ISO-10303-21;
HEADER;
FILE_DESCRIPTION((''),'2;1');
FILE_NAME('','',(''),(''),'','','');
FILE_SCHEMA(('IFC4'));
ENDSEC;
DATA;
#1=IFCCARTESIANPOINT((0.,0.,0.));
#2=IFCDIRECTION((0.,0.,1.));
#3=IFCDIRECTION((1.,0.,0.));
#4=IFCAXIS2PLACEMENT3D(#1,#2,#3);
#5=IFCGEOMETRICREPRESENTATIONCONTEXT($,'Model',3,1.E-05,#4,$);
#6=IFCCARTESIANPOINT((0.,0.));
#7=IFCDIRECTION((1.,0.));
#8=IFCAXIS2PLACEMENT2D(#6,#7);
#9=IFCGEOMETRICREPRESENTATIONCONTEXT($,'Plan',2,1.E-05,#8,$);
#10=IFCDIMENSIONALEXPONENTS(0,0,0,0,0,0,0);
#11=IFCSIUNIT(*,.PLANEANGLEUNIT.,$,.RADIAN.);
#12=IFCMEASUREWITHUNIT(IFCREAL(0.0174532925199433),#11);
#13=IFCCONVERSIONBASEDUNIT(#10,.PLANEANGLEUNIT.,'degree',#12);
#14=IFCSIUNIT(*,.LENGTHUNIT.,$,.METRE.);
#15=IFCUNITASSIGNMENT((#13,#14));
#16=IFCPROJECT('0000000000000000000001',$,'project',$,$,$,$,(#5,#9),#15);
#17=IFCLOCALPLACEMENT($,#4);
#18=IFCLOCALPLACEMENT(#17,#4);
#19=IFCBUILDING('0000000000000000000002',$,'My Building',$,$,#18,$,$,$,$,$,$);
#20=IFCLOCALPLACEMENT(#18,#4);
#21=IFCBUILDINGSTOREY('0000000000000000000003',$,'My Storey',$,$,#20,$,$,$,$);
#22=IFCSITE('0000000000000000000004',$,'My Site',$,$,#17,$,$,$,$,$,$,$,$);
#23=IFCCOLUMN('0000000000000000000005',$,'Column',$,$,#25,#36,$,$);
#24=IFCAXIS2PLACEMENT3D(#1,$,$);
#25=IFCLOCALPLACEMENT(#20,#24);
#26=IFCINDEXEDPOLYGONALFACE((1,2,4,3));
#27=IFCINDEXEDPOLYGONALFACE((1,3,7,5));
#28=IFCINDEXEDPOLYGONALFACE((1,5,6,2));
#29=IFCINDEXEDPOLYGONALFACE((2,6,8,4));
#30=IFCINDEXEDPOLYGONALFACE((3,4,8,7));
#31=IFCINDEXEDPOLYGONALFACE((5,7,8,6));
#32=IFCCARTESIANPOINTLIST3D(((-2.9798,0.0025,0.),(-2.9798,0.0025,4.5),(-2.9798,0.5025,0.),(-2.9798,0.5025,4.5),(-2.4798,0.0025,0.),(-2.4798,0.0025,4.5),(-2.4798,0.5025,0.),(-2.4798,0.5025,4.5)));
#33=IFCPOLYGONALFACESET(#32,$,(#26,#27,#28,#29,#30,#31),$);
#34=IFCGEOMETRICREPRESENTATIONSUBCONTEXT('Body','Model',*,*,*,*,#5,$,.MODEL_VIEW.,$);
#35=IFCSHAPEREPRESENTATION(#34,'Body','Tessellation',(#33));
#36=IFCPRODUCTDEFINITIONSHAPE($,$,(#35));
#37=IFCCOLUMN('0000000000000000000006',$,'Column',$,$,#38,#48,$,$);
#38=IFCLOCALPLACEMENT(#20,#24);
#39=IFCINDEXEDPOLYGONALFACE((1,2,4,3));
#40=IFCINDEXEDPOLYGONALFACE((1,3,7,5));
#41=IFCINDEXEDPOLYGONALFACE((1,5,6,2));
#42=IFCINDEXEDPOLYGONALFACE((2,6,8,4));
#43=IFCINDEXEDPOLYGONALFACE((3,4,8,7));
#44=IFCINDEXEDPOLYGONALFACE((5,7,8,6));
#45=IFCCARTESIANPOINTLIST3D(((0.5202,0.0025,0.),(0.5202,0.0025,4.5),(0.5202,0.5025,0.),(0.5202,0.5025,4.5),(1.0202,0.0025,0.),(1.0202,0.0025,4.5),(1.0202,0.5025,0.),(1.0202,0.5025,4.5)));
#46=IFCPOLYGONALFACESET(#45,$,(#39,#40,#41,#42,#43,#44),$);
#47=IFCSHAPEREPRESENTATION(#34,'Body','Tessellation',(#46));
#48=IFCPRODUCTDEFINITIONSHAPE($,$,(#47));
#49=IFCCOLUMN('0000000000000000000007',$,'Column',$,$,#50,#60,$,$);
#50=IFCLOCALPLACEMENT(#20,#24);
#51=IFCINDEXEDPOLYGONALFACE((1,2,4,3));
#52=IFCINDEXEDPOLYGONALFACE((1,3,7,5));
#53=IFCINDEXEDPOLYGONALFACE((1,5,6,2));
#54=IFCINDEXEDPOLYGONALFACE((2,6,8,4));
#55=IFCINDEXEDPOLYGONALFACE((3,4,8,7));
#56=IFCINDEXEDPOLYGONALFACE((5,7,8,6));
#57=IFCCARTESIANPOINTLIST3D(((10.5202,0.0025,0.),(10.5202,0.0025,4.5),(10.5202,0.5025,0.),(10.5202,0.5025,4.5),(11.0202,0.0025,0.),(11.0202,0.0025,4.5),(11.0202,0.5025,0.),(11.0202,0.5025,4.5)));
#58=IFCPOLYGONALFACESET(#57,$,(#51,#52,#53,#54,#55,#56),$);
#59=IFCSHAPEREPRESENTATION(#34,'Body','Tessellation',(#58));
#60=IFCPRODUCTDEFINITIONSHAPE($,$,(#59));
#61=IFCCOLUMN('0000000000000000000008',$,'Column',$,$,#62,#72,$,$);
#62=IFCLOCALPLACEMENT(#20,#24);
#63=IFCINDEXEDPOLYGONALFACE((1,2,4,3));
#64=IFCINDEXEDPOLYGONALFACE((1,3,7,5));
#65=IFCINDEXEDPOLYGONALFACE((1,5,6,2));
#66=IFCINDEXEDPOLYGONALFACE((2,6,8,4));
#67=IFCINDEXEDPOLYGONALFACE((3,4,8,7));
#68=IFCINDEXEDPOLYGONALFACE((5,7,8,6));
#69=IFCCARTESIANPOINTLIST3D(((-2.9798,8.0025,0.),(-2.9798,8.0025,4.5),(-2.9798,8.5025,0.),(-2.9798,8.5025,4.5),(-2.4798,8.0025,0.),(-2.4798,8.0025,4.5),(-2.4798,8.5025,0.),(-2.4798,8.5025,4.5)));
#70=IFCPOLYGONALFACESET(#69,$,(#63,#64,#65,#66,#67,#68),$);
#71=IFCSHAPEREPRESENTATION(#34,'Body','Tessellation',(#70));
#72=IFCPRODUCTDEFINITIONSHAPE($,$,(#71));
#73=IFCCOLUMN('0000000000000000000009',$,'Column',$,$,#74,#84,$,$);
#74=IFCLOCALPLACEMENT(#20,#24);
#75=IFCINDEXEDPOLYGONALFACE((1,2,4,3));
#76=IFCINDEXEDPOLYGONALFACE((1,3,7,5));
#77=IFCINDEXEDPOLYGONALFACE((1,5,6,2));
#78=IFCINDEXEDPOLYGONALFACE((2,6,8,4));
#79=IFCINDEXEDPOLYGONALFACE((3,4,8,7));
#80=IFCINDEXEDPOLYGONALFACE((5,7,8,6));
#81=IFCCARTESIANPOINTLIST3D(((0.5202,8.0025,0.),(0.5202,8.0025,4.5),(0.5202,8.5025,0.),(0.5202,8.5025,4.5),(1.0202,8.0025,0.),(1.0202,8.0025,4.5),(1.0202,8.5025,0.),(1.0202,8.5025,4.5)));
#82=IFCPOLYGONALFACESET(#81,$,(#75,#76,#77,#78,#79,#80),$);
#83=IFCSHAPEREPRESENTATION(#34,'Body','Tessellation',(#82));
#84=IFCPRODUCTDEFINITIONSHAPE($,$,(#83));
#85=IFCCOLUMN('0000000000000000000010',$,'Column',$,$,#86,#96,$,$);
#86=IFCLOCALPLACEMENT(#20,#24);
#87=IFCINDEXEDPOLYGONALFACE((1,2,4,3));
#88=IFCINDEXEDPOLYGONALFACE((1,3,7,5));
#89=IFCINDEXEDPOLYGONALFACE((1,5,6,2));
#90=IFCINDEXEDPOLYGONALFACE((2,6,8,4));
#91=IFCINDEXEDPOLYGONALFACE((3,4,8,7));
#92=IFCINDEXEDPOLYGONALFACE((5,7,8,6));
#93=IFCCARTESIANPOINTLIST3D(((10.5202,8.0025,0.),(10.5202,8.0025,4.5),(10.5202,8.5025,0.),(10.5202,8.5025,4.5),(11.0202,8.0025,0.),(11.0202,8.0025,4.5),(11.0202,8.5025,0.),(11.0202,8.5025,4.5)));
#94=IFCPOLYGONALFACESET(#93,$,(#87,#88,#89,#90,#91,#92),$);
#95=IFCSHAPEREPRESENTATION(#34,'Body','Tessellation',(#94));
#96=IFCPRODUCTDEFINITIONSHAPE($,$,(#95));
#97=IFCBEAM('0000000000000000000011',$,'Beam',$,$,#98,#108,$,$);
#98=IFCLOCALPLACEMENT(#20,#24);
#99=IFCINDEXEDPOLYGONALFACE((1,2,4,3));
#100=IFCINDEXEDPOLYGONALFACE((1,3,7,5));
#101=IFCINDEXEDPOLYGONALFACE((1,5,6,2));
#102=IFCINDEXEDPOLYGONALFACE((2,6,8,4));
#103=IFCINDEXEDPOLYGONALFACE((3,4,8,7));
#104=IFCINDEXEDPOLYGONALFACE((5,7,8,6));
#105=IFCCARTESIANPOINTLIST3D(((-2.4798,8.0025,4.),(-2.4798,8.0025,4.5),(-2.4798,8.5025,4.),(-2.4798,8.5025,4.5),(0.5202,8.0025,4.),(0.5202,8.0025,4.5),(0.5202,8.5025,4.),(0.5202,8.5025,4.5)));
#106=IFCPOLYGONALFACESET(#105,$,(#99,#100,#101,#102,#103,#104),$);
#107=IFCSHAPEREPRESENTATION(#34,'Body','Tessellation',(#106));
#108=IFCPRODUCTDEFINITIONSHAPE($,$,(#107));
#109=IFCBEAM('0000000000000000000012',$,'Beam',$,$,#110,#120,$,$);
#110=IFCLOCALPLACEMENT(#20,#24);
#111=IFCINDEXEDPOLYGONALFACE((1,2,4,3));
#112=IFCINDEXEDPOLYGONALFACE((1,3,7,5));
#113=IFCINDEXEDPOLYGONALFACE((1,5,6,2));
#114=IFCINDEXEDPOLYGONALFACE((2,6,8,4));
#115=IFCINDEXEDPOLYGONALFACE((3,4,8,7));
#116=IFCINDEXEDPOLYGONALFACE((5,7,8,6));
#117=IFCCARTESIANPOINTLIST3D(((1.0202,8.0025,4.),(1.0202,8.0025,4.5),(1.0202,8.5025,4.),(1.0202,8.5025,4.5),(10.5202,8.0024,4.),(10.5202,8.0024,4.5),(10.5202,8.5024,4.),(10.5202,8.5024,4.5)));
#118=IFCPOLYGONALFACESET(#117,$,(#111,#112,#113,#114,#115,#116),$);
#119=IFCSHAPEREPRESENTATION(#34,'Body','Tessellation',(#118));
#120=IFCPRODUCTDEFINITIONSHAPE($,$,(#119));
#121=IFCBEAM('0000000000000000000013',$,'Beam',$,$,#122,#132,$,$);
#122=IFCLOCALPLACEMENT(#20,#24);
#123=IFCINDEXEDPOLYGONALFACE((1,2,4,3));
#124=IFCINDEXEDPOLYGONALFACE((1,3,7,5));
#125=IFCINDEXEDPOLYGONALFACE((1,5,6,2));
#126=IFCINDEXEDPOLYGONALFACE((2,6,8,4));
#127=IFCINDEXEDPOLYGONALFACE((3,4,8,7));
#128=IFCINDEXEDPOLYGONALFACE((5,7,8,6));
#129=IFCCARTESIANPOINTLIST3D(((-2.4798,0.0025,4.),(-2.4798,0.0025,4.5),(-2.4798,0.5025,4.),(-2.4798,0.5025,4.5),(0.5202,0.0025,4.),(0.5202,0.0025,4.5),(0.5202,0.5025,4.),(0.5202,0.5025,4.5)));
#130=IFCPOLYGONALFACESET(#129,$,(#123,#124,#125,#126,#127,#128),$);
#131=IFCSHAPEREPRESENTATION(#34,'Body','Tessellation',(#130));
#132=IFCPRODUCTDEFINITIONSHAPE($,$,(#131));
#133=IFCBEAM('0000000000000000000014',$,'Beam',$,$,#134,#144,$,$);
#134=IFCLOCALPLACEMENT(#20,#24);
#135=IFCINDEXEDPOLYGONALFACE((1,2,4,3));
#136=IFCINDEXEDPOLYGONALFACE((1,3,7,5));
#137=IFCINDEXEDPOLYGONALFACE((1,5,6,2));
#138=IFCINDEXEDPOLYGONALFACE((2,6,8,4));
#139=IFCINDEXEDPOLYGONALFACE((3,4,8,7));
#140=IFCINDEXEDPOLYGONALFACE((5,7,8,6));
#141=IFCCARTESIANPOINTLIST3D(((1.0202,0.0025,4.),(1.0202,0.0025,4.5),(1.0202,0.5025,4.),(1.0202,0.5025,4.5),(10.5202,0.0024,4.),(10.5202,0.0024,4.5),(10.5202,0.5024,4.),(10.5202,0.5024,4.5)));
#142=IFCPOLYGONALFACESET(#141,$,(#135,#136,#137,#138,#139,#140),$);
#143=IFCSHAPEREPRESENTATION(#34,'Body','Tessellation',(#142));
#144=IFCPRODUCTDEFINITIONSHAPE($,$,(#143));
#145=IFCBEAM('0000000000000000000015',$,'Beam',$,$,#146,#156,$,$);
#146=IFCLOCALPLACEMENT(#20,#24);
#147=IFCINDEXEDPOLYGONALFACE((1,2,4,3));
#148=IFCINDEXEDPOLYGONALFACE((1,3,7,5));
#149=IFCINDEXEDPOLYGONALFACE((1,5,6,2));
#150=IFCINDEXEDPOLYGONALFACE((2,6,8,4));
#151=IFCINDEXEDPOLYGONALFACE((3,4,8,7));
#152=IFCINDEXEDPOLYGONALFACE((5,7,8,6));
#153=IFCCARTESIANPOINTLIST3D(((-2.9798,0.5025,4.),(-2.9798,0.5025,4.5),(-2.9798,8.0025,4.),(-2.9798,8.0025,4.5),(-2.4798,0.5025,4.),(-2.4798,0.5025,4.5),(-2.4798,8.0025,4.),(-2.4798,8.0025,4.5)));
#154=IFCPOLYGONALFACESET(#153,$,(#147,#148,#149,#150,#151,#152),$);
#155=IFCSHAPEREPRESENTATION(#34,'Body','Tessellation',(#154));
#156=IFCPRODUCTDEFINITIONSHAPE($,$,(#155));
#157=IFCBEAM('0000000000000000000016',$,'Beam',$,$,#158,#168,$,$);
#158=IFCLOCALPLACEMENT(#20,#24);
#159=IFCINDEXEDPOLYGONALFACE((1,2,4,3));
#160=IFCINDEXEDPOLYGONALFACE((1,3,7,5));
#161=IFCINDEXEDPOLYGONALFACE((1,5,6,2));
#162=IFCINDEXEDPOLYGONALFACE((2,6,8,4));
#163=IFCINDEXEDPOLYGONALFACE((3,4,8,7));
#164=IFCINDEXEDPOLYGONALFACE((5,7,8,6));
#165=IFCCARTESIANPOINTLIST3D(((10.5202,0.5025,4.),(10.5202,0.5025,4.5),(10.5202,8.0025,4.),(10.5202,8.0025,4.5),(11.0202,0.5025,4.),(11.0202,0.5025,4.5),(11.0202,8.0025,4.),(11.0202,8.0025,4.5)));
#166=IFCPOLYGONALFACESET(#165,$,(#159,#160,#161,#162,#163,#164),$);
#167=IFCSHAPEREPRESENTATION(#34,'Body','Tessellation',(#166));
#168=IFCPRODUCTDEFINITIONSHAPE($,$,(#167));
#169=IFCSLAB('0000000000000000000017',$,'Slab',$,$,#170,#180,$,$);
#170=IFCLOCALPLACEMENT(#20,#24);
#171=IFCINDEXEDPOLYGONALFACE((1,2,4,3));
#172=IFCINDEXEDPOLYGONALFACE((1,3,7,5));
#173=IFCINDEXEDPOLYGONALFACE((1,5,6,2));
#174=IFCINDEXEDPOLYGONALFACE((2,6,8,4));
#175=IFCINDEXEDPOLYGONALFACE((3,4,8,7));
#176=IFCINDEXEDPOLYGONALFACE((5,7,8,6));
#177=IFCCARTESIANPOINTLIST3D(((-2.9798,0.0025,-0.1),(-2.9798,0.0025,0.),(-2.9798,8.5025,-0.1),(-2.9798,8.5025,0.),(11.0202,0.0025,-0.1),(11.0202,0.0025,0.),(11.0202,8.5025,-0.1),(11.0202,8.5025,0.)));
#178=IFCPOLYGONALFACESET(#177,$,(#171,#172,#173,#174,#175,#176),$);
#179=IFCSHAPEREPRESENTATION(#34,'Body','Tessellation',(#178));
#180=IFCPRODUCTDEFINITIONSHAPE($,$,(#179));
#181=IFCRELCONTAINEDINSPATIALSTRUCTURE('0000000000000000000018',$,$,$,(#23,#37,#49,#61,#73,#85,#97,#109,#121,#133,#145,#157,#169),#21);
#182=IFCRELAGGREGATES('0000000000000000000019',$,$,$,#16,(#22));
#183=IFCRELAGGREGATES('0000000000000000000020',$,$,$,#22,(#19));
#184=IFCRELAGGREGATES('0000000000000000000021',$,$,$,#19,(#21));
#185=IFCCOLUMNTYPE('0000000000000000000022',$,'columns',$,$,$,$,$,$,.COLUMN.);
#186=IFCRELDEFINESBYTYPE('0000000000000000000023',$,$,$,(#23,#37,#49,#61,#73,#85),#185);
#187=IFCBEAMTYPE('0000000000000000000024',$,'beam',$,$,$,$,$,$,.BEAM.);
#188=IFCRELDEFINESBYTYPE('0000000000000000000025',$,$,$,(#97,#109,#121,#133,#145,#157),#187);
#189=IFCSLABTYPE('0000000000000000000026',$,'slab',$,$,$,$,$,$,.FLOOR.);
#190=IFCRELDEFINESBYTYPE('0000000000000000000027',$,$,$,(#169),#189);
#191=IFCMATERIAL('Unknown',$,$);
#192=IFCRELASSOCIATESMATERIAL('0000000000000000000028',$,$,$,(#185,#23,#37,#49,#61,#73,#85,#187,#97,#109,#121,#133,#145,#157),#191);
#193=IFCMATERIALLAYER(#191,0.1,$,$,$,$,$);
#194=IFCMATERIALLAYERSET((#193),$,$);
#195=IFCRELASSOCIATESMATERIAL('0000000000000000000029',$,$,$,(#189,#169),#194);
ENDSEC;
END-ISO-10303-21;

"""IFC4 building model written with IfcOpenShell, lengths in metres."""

from ifc_helpers import new_model, entity, si_unit, converted_unit, frame, origin_with_axes, origin_2d_with_axis, place, context, subcontext, project, spatial, indexed_curve, rectangle, outline, extrude, material, layer, layer_set, layer_usage, material_profile, profile_set, profile_usage, type_object, element, save


model = new_model("IFC4")

# Units and contexts
model_context = context("Model", 3, precision=1e-05, world=origin_with_axes())
plan_context = context("Plan", 2, precision=1e-05, world=origin_2d_with_axis())
body_context_1 = subcontext(model_context, "Body", "Model", "MODEL_VIEW")
ifc_project = project(units=[converted_unit("PLANEANGLEUNIT", "degree", entity("IfcReal", 0.0174532925199433), si_unit("PLANEANGLEUNIT", "RADIAN"), dimensions=[0, 0, 0, 0, 0, 0, 0]), si_unit("LENGTHUNIT", "METRE")], contexts=[model_context, plan_context])

# Site, building, storey
site_placement = place(None, origin_with_axes())
site = spatial("IfcSite", under=ifc_project, at=site_placement, Name="My Site")
building_placement = place(site_placement, origin_with_axes())
building = spatial("IfcBuilding", under=site, at=building_placement, Name="My Building")
storey_placement = place(building_placement, origin_with_axes())
storey = spatial("IfcBuildingStorey", under=building, at=storey_placement, Name="My Storey")

# Columns
ifc_material = material(Name="Unknown")
ifc_material_profile_1 = material_profile(ifc_material, rectangle(XDim=0.5, YDim=0.5))
ifc_profile_set_1 = profile_set([ifc_material_profile_1])
ifc_profile_usage_1 = profile_usage(ifc_profile_set_1, cardinal=5)
column_type = type_object("IfcColumnType", Name="columns", PredefinedType="COLUMN", material=ifc_profile_set_1)
column_1_placement = place(storey_placement, frame((-2.7298, 0.2525, 0.0), z_axis=(0.0, 0.0, 1.0), x_axis=(1.0, 0.0, 0.0)))
element("IfcColumn", 1, at=column_1_placement, inside=storey, type_object=column_type, material=ifc_profile_usage_1, Name="Column", context=body_context_1, shape_type="SweptSolid", body=[
    extrude(rectangle(XDim=0.5, YDim=0.5), origin_with_axes(), (0.0, 0.0, 1.0), 4.5),
])
ifc_profile_usage_2 = profile_usage(ifc_profile_set_1, cardinal=5)
column_2_placement = place(storey_placement, frame((0.7702, 0.2525, 0.0), z_axis=(0.0, 0.0, 1.0), x_axis=(1.0, 0.0, 0.0)))
element("IfcColumn", 2, at=column_2_placement, inside=storey, type_object=column_type, material=ifc_profile_usage_2, Name="Column", context=body_context_1, shape_type="SweptSolid", body=[
    extrude(rectangle(XDim=0.5, YDim=0.5), origin_with_axes(), (0.0, 0.0, 1.0), 4.5),
])
ifc_profile_usage_3 = profile_usage(ifc_profile_set_1, cardinal=5)
column_3_placement = place(storey_placement, frame((10.7702, 0.2525, 0.0), z_axis=(0.0, 0.0, 1.0), x_axis=(1.0, 0.0, 0.0)))
element("IfcColumn", 3, at=column_3_placement, inside=storey, type_object=column_type, material=ifc_profile_usage_3, Name="Column", context=body_context_1, shape_type="SweptSolid", body=[
    extrude(rectangle(XDim=0.5, YDim=0.5), origin_with_axes(), (0.0, 0.0, 1.0), 4.5),
])
ifc_profile_usage_4 = profile_usage(ifc_profile_set_1, cardinal=5)
column_4_placement = place(storey_placement, frame((-2.7298, 8.2525, 0.0), z_axis=(0.0, 0.0, 1.0), x_axis=(1.0, 0.0, 0.0)))
element("IfcColumn", 4, at=column_4_placement, inside=storey, type_object=column_type, material=ifc_profile_usage_4, Name="Column", context=body_context_1, shape_type="SweptSolid", body=[
    extrude(rectangle(XDim=0.5, YDim=0.5), origin_with_axes(), (0.0, 0.0, 1.0), 4.5),
])
ifc_profile_usage_5 = profile_usage(ifc_profile_set_1, cardinal=5)
column_5_placement = place(storey_placement, frame((0.7702, 8.2525, 0.0), z_axis=(0.0, 0.0, 1.0), x_axis=(1.0, 0.0, 0.0)))
element("IfcColumn", 5, at=column_5_placement, inside=storey, type_object=column_type, material=ifc_profile_usage_5, Name="Column", context=body_context_1, shape_type="SweptSolid", body=[
    extrude(rectangle(XDim=0.5, YDim=0.5), origin_with_axes(), (0.0, 0.0, 1.0), 4.5),
])
ifc_profile_usage_6 = profile_usage(ifc_profile_set_1, cardinal=5)
column_6_placement = place(storey_placement, frame((10.7702, 8.2525, 0.0), z_axis=(0.0, 0.0, 1.0), x_axis=(1.0, 0.0, 0.0)))
element("IfcColumn", 6, at=column_6_placement, inside=storey, type_object=column_type, material=ifc_profile_usage_6, Name="Column", context=body_context_1, shape_type="SweptSolid", body=[
    extrude(rectangle(XDim=0.5, YDim=0.5), origin_with_axes(), (0.0, 0.0, 1.0), 4.5),
])

# Beams
ifc_material_profile_2 = material_profile(ifc_material, rectangle(XDim=0.5, YDim=0.5))
ifc_profile_set_2 = profile_set([ifc_material_profile_2])
ifc_profile_usage_7 = profile_usage(ifc_profile_set_2, cardinal=7)
beam_type = type_object("IfcBeamType", Name="beam", PredefinedType="BEAM", material=ifc_profile_set_2)
beam_1_placement = place(storey_placement, frame((-2.4798, 8.5025, 4.5), z_axis=(1.0, 0.0, 0.0), x_axis=(0.0, 1.0, 0.0)))
element("IfcBeam", 7, at=beam_1_placement, inside=storey, type_object=beam_type, material=ifc_profile_usage_7, Name="Beam", context=body_context_1, shape_type="SweptSolid", body=[
    extrude(rectangle(XDim=0.5, YDim=0.5), frame((-0.25, -0.25, 0.0), z_axis=(0.0, 0.0, 1.0), x_axis=(1.0, 0.0, 0.0)), (0.0, 0.0, 1.0), 3.0),
])
ifc_profile_usage_8 = profile_usage(ifc_profile_set_2, cardinal=7)
beam_2_placement = place(storey_placement, frame((1.0202, 8.5025, 4.5), z_axis=(1.0, 0.0, 0.0), x_axis=(0.0, 1.0, 0.0)))
element("IfcBeam", 8, at=beam_2_placement, inside=storey, type_object=beam_type, material=ifc_profile_usage_8, Name="Beam", context=body_context_1, shape_type="SweptSolid", body=[
    extrude(rectangle(XDim=0.5, YDim=0.5), frame((-0.25, -0.25, 0.0), z_axis=(0.0, 0.0, 1.0), x_axis=(1.0, 0.0, 0.0)), (0.0, 0.0, 1.0), 9.5),
])
ifc_profile_usage_9 = profile_usage(ifc_profile_set_2, cardinal=7)
beam_3_placement = place(storey_placement, frame((-2.4798, 0.5025, 4.5), z_axis=(1.0, 0.0, 0.0), x_axis=(0.0, 1.0, 0.0)))
element("IfcBeam", 9, at=beam_3_placement, inside=storey, type_object=beam_type, material=ifc_profile_usage_9, Name="Beam", context=body_context_1, shape_type="SweptSolid", body=[
    extrude(rectangle(XDim=0.5, YDim=0.5), frame((-0.25, -0.25, 0.0), z_axis=(0.0, 0.0, 1.0), x_axis=(1.0, 0.0, 0.0)), (0.0, 0.0, 1.0), 3.0),
])
ifc_profile_usage_10 = profile_usage(ifc_profile_set_2, cardinal=7)
beam_4_placement = place(storey_placement, frame((1.0202, 0.5025, 4.5), z_axis=(1.0, 0.0, 0.0), x_axis=(0.0, 1.0, 0.0)))
element("IfcBeam", 10, at=beam_4_placement, inside=storey, type_object=beam_type, material=ifc_profile_usage_10, Name="Beam", context=body_context_1, shape_type="SweptSolid", body=[
    extrude(rectangle(XDim=0.5, YDim=0.5), frame((-0.25, -0.25, 0.0), z_axis=(0.0, 0.0, 1.0), x_axis=(1.0, 0.0, 0.0)), (0.0, 0.0, 1.0), 9.5),
])
ifc_profile_usage_11 = profile_usage(ifc_profile_set_2, cardinal=7)
beam_5_placement = place(storey_placement, frame((-2.4798, 8.0025, 4.5), z_axis=(0.0, -1.0, 0.0), x_axis=(1.0, 0.0, 0.0)))
element("IfcBeam", 11, at=beam_5_placement, inside=storey, type_object=beam_type, material=ifc_profile_usage_11, Name="Beam", context=body_context_1, shape_type="SweptSolid", body=[
    extrude(rectangle(XDim=0.5, YDim=0.5), frame((-0.25, -0.25, 0.0), z_axis=(0.0, 0.0, 1.0), x_axis=(1.0, 0.0, 0.0)), (0.0, 0.0, 1.0), 7.5),
])
ifc_profile_usage_12 = profile_usage(ifc_profile_set_2, cardinal=7)
beam_6_placement = place(storey_placement, frame((11.0202, 8.0025, 4.5), z_axis=(0.0, -1.0, 0.0), x_axis=(1.0, 0.0, 0.0)))
element("IfcBeam", 12, at=beam_6_placement, inside=storey, type_object=beam_type, material=ifc_profile_usage_12, Name="Beam", context=body_context_1, shape_type="SweptSolid", body=[
    extrude(rectangle(XDim=0.5, YDim=0.5), frame((-0.25, -0.25, 0.0), z_axis=(0.0, 0.0, 1.0), x_axis=(1.0, 0.0, 0.0)), (0.0, 0.0, 1.0), 7.5),
])

# Slab
ifc_layer_1 = layer(ifc_material, 0.1)
ifc_layer_set_1 = layer_set([ifc_layer_1])
ifc_layer_usage_1 = layer_usage(ifc_layer_set_1, "AXIS3", "POSITIVE", -0.1)
slab_type = type_object("IfcSlabType", Name="slab", PredefinedType="FLOOR", material=ifc_layer_set_1)
slab_placement = place(storey_placement, frame((-2.9798, 8.5025, 0.0), z_axis=(0.0, 0.0, 1.0), x_axis=(1.0, 0.0, 0.0)))
element("IfcSlab", 13, at=slab_placement, inside=storey, type_object=slab_type, material=ifc_layer_usage_1, Name="Slab", context=body_context_1, shape_type="SweptSolid", body=[
    extrude(outline(indexed_curve([(0.0, 0.0), (14.0, 0.0), (14.0, -8.5), (0.0, -8.5), (0.0, 0.0)])), frame((0.0, 0.0, -0.1), z_axis=(0.0, 0.0, 1.0), x_axis=(1.0, 0.0, 0.0)), (0.0, 0.0, 1.0), 0.1),
])

save(model, "model.ifc")
